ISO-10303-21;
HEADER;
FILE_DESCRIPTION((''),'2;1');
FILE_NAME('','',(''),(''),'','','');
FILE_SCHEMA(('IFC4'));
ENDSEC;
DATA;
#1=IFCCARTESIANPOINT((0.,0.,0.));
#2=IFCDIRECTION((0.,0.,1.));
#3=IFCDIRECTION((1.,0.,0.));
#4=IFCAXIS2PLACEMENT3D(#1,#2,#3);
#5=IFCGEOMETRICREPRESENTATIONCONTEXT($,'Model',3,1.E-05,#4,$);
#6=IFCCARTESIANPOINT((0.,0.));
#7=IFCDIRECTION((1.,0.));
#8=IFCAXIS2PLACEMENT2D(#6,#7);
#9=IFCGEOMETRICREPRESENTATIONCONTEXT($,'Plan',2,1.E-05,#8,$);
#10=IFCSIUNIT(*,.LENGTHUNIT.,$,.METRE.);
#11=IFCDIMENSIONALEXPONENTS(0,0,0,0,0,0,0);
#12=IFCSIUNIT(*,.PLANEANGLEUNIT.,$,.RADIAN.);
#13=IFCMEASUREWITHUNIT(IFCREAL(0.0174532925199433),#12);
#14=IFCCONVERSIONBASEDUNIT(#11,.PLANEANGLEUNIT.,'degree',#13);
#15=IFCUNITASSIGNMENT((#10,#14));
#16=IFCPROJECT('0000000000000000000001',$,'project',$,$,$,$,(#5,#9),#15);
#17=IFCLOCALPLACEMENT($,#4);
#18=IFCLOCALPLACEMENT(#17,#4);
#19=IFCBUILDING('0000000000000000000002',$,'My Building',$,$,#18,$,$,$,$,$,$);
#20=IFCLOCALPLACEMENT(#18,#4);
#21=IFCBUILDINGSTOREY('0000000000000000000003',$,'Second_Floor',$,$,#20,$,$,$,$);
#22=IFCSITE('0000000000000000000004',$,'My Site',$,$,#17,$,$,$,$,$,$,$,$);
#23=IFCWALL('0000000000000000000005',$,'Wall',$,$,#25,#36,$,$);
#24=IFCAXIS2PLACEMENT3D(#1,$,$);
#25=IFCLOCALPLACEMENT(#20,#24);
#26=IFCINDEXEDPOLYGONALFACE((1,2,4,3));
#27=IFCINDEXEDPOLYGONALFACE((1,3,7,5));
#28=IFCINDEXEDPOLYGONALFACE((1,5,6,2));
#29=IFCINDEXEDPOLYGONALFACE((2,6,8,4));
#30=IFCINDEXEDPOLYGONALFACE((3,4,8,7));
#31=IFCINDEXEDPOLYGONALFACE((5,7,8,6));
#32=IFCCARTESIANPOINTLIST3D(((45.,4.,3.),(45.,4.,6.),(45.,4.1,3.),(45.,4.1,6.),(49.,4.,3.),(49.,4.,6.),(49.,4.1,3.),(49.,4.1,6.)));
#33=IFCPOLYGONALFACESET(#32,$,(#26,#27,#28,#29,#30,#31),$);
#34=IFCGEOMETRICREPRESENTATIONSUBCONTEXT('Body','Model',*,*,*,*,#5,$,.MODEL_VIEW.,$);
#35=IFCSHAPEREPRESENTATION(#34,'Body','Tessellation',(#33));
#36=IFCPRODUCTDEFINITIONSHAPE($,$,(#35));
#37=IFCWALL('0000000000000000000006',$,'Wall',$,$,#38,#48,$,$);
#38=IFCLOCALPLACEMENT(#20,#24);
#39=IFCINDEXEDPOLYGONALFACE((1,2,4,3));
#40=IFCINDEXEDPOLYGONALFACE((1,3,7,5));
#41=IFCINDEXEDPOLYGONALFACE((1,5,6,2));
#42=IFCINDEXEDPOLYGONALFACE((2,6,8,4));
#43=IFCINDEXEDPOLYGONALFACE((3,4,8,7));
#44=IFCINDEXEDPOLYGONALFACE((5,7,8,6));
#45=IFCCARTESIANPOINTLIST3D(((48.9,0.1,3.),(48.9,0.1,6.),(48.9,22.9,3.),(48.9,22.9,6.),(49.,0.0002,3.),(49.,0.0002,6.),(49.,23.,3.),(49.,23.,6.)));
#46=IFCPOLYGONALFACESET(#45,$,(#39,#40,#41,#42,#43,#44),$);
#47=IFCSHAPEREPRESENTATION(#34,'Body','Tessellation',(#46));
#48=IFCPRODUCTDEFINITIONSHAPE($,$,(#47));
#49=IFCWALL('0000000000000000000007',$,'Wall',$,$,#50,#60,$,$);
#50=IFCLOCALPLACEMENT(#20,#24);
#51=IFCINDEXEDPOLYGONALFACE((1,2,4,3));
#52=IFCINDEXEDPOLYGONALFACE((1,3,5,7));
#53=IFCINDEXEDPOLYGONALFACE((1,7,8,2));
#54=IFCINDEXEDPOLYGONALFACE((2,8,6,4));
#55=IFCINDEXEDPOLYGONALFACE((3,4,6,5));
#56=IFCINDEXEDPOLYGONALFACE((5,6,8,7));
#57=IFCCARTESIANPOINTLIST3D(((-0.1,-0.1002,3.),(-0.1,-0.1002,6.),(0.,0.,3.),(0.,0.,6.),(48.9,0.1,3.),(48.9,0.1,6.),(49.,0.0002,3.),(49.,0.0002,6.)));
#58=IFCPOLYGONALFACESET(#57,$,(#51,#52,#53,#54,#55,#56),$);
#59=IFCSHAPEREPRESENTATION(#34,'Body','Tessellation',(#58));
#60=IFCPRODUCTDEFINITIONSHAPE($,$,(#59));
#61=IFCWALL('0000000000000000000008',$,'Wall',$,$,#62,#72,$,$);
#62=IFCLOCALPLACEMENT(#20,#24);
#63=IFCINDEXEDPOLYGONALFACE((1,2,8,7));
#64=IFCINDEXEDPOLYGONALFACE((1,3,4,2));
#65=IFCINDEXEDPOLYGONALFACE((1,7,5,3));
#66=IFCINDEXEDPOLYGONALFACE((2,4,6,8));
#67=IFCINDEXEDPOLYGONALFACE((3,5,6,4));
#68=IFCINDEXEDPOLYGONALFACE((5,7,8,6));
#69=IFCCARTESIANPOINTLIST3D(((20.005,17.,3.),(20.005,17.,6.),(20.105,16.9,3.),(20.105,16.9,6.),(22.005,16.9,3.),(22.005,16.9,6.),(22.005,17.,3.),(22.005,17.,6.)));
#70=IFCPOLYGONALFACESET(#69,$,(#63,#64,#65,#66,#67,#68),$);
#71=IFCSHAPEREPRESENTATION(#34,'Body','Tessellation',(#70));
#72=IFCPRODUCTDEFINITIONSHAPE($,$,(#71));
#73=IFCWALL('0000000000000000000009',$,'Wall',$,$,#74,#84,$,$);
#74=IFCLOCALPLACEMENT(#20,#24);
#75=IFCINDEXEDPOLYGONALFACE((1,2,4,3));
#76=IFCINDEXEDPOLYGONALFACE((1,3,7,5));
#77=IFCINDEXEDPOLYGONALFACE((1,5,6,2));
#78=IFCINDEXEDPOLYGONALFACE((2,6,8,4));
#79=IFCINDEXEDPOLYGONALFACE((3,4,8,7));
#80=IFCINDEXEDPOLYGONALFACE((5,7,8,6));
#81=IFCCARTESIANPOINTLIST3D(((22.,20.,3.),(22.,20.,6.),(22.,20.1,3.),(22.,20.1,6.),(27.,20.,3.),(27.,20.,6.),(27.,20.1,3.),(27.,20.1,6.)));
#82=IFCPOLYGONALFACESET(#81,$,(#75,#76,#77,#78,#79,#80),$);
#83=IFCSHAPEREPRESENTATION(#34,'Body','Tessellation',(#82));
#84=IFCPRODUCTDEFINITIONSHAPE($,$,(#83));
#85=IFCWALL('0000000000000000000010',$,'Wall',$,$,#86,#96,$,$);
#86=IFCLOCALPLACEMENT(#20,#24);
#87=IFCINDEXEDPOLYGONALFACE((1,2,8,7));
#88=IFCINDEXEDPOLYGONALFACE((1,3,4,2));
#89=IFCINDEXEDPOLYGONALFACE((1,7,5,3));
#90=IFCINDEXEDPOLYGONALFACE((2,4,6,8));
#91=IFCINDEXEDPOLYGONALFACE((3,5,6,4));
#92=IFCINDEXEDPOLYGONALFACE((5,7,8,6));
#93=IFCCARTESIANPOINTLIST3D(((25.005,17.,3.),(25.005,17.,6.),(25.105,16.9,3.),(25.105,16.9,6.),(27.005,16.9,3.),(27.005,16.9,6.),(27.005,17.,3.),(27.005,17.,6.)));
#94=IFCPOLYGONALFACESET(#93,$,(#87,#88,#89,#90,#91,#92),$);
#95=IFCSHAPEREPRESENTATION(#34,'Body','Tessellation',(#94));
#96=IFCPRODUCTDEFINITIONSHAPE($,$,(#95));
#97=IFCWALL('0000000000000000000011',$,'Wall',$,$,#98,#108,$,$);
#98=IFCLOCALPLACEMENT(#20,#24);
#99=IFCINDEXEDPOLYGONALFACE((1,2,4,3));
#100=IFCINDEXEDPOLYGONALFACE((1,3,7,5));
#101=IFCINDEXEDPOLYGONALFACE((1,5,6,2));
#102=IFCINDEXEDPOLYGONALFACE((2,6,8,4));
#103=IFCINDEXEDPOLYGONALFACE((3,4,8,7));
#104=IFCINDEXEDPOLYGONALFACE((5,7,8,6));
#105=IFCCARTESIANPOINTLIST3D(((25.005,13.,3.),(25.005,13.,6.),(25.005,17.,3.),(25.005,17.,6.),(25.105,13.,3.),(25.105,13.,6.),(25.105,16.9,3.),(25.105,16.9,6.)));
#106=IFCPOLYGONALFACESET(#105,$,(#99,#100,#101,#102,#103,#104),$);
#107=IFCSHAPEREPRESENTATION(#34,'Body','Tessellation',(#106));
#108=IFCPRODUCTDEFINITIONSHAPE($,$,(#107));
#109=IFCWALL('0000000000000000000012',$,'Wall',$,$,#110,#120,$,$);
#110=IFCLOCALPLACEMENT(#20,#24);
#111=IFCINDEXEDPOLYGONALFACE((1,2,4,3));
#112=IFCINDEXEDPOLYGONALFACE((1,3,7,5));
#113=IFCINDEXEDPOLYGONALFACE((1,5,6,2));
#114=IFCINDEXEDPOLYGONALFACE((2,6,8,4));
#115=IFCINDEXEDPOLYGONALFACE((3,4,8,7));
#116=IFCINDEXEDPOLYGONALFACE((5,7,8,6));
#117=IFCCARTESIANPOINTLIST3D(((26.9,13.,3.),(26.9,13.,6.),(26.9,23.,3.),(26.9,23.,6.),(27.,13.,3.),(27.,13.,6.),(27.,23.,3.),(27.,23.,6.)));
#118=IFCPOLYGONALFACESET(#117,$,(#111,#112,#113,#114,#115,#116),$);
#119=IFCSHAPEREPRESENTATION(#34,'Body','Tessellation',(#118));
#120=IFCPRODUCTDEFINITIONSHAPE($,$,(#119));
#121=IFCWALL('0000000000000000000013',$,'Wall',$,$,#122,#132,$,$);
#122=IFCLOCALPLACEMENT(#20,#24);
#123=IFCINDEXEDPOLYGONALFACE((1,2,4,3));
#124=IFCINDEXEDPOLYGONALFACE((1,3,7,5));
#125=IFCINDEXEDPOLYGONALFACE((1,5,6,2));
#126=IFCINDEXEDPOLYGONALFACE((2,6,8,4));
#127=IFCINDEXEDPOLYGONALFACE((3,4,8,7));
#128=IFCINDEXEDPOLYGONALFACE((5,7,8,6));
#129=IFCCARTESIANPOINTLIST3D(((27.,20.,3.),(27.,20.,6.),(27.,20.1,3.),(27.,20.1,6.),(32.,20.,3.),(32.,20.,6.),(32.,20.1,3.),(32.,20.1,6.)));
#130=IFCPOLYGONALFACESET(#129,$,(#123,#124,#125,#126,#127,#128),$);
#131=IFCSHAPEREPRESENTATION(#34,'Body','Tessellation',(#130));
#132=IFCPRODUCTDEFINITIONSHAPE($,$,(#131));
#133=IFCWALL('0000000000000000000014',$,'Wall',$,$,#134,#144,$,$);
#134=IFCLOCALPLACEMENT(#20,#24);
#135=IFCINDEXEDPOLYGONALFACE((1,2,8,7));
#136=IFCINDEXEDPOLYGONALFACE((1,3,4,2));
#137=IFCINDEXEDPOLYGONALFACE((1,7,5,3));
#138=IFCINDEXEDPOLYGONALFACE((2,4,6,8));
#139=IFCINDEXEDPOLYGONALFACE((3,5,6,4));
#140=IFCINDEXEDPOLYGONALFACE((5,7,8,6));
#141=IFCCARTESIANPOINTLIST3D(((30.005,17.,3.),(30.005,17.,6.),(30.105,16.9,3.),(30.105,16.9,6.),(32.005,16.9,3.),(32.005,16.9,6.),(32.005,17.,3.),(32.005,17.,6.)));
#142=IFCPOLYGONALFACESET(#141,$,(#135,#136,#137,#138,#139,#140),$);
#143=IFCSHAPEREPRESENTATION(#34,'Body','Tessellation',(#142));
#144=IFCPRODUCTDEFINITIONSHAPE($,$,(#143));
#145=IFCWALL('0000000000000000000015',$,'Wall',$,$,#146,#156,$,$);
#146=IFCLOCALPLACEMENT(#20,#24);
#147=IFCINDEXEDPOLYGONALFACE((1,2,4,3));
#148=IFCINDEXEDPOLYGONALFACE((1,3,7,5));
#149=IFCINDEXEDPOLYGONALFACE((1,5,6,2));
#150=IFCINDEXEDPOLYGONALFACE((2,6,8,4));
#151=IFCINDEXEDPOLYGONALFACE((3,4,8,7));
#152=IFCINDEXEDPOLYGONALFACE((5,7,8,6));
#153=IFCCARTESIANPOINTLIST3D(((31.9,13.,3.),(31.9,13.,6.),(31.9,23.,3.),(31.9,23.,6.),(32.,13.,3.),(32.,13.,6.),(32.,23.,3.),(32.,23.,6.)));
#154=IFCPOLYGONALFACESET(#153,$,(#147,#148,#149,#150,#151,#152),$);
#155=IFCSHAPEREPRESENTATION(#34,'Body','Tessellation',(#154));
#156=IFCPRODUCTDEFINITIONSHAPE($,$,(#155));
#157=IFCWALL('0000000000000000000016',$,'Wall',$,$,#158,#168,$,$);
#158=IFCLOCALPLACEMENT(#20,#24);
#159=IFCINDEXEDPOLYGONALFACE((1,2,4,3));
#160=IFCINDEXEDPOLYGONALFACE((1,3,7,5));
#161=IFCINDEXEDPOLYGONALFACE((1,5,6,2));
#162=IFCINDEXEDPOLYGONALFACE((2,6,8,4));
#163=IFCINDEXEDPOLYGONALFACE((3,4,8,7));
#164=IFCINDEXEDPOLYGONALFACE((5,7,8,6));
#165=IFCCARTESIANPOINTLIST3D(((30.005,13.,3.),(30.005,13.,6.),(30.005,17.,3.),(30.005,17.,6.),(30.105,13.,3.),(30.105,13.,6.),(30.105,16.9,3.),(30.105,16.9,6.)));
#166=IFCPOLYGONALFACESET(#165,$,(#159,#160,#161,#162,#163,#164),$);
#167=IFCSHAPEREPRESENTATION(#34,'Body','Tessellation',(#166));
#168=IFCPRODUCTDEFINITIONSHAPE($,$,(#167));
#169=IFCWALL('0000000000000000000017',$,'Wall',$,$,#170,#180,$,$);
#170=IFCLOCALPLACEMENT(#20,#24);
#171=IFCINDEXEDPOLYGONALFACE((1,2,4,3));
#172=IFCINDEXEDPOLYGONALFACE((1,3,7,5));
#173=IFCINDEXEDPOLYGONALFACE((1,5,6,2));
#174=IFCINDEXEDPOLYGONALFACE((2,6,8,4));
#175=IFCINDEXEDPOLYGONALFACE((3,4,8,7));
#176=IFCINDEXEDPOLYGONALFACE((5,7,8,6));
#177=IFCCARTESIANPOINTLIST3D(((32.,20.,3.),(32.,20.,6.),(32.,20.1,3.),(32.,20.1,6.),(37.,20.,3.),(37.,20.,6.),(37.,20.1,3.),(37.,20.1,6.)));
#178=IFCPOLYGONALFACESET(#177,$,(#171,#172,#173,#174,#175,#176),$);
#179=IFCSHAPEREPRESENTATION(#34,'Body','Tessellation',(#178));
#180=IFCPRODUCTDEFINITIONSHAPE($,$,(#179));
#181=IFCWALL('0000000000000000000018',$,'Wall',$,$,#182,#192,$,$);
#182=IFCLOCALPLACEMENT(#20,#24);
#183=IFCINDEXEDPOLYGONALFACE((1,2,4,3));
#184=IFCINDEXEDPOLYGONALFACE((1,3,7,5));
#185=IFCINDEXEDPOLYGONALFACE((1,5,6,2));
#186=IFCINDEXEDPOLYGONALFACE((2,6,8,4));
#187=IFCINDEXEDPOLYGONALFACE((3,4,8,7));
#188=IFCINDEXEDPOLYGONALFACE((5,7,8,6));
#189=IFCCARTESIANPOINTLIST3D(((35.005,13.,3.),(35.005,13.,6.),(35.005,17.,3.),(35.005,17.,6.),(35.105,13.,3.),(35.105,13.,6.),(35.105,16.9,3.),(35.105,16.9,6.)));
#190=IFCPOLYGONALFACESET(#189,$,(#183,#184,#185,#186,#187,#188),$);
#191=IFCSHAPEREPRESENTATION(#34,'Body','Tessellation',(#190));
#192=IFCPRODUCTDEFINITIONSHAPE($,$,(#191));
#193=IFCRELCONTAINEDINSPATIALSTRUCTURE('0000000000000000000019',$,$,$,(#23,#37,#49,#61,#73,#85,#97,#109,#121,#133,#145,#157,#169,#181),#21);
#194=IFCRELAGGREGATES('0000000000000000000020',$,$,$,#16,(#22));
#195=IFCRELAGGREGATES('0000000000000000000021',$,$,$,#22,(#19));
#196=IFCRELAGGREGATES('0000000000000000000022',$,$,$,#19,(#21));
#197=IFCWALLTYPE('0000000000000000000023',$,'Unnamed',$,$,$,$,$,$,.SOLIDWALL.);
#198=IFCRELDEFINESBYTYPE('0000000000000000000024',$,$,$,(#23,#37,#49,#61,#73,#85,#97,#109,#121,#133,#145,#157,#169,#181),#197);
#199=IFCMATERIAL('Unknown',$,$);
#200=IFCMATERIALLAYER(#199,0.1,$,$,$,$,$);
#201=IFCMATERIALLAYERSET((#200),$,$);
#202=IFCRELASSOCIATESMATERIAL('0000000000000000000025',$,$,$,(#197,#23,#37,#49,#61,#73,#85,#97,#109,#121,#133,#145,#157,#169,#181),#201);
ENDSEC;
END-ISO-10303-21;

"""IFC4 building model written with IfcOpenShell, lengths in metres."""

from ifc_helpers import new_model, entity, si_unit, converted_unit, frame, origin_with_axes, origin_2d_with_axis, place, context, subcontext, project, spatial, line, indexed_curve, outline, extrude, material, layer, layer_set, layer_usage, type_object, element, save


model = new_model("IFC4")

# Units and contexts
model_context = context("Model", 3, precision=1e-05, world=origin_with_axes())
plan_context = context("Plan", 2, precision=1e-05, world=origin_2d_with_axis())
body_context = subcontext(model_context, "Body", "Model", "MODEL_VIEW")
ifc_project = project(units=[si_unit("LENGTHUNIT", "METRE"), converted_unit("PLANEANGLEUNIT", "degree", entity("IfcReal", 0.0174532925199433), si_unit("PLANEANGLEUNIT", "RADIAN"), dimensions=[0, 0, 0, 0, 0, 0, 0])], contexts=[model_context, plan_context])

# Site, building, storey
site_placement = place(None, origin_with_axes())
site = spatial("IfcSite", under=ifc_project, at=site_placement, Name="My Site")
building_placement = place(site_placement, origin_with_axes())
building = spatial("IfcBuilding", under=site, at=building_placement, Name="My Building")
storey_placement = place(building_placement, origin_with_axes())
storey = spatial("IfcBuildingStorey", under=building, at=storey_placement, Name="Second_Floor")

# Walls
ifc_material = material(Name="Unknown")
ifc_layer = layer(ifc_material, 0.1)
ifc_layer_set = layer_set([ifc_layer])
wall_type = type_object("IfcWallType", Name="Unnamed", PredefinedType="SOLIDWALL", material=ifc_layer_set)
ifc_layer_usage_1 = layer_usage(ifc_layer_set, "AXIS2", "POSITIVE", 0.0)
wall_1_placement = place(storey_placement, frame((45.0, 4.0, 3.0), z_axis=(0.0, 0.0, 1.0), x_axis=(1.0, 0.0, 0.0)))
element("IfcWall", 1, at=wall_1_placement, inside=storey, type_object=wall_type, material=ifc_layer_usage_1, Name="Wall", context=body_context, shape_type="SweptSolid", body=[
    extrude(outline(indexed_curve([(0.0, 0.0), (0.0, 0.1), (4.0, 0.1), (4.0, 0.0)], segments=[line(1, 2, 3, 4, 1)])), origin_with_axes(), (0.0, 0.0, 1.0), 3.0),
])
ifc_layer_usage_2 = layer_usage(ifc_layer_set, "AXIS2", "POSITIVE", 0.0)
wall_2_placement = place(storey_placement, frame((48.9, 22.9, 3.0), z_axis=(0.0, 0.0, 1.0), x_axis=(0.0, -1.0, 0.0)))
element("IfcWall", 2, at=wall_2_placement, inside=storey, type_object=wall_type, material=ifc_layer_usage_2, Name="Wall", context=body_context, shape_type="SweptSolid", body=[
    extrude(outline(indexed_curve([(0.0, 0.0), (-0.1, 0.1), (22.8998, 0.1), (22.8, 0.0)], segments=[line(1, 2, 3, 4, 1)])), origin_with_axes(), (0.0, 0.0, 1.0), 3.0),
])
ifc_layer_usage_3 = layer_usage(ifc_layer_set, "AXIS2", "POSITIVE", 0.0)
wall_3_placement = place(storey_placement, frame((48.9, 0.1, 3.0), z_axis=(0.0, 0.0, 1.0), x_axis=(-0.999998, -0.002045, 0.0)))
element("IfcWall", 3, at=wall_3_placement, inside=storey, type_object=wall_type, material=ifc_layer_usage_3, Name="Wall", context=body_context, shape_type="SweptSolid", body=[
    extrude(outline(indexed_curve([(0.0, 0.0), (-0.0998, 0.1), (49.0003, 0.1), (48.9001, 0.0)], segments=[line(1, 2, 3, 4, 1)])), origin_with_axes(), (0.0, 0.0, 1.0), 3.0),
])
ifc_layer_usage_4 = layer_usage(ifc_layer_set, "AXIS2", "POSITIVE", 0.0)
wall_4_placement = place(storey_placement, frame((22.005, 17.0, 3.0), z_axis=(0.0, 0.0, 1.0), x_axis=(-1.0, 0.0, 0.0)))
element("IfcWall", 4, at=wall_4_placement, inside=storey, type_object=wall_type, material=ifc_layer_usage_4, Name="Wall", context=body_context, shape_type="SweptSolid", body=[
    extrude(outline(indexed_curve([(0.0, 0.0), (0.0, 0.1), (1.9, 0.1), (2.0, 0.0)], segments=[line(1, 2, 3, 4, 1)])), origin_with_axes(), (0.0, 0.0, 1.0), 3.0),
])
ifc_layer_usage_5 = layer_usage(ifc_layer_set, "AXIS2", "POSITIVE", 0.0)
wall_5_placement = place(storey_placement, frame((22.0, 20.0, 3.0), z_axis=(0.0, 0.0, 1.0), x_axis=(1.0, 0.0, 0.0)))
element("IfcWall", 5, at=wall_5_placement, inside=storey, type_object=wall_type, material=ifc_layer_usage_5, Name="Wall", context=body_context, shape_type="SweptSolid", body=[
    extrude(outline(indexed_curve([(0.0, 0.0), (0.0, 0.1), (5.0, 0.1), (5.0, 0.0)], segments=[line(1, 2, 3, 4, 1)])), origin_with_axes(), (0.0, 0.0, 1.0), 3.0),
])
ifc_layer_usage_6 = layer_usage(ifc_layer_set, "AXIS2", "POSITIVE", 0.0)
wall_6_placement = place(storey_placement, frame((27.005, 17.0, 3.0), z_axis=(0.0, 0.0, 1.0), x_axis=(-1.0, 0.0, 0.0)))
element("IfcWall", 6, at=wall_6_placement, inside=storey, type_object=wall_type, material=ifc_layer_usage_6, Name="Wall", context=body_context, shape_type="SweptSolid", body=[
    extrude(outline(indexed_curve([(0.0, 0.0), (0.0, 0.1), (1.9, 0.1), (2.0, 0.0)], segments=[line(1, 2, 3, 4, 1)])), origin_with_axes(), (0.0, 0.0, 1.0), 3.0),
])
ifc_layer_usage_7 = layer_usage(ifc_layer_set, "AXIS2", "POSITIVE", 0.0)
wall_7_placement = place(storey_placement, frame((25.005, 17.0, 3.0), z_axis=(0.0, 0.0, 1.0), x_axis=(0.0, -1.0, 0.0)))
element("IfcWall", 7, at=wall_7_placement, inside=storey, type_object=wall_type, material=ifc_layer_usage_7, Name="Wall", context=body_context, shape_type="SweptSolid", body=[
    extrude(outline(indexed_curve([(0.0, 0.0), (0.1, 0.1), (4.0, 0.1), (4.0, 0.0)], segments=[line(1, 2, 3, 4, 1)])), origin_with_axes(), (0.0, 0.0, 1.0), 3.0),
])
ifc_layer_usage_8 = layer_usage(ifc_layer_set, "AXIS2", "POSITIVE", 0.0)
wall_8_placement = place(storey_placement, frame((26.9, 23.0, 3.0), z_axis=(0.0, 0.0, 1.0), x_axis=(0.0, -1.0, 0.0)))
element("IfcWall", 8, at=wall_8_placement, inside=storey, type_object=wall_type, material=ifc_layer_usage_8, Name="Wall", context=body_context, shape_type="SweptSolid", body=[
    extrude(outline(indexed_curve([(0.0, 0.0), (0.0, 0.1), (10.0, 0.1), (10.0, 0.0)], segments=[line(1, 2, 3, 4, 1)])), origin_with_axes(), (0.0, 0.0, 1.0), 3.0),
])
ifc_layer_usage_9 = layer_usage(ifc_layer_set, "AXIS2", "POSITIVE", 0.0)
wall_9_placement = place(storey_placement, frame((27.0, 20.0, 3.0), z_axis=(0.0, 0.0, 1.0), x_axis=(1.0, 0.0, 0.0)))
element("IfcWall", 9, at=wall_9_placement, inside=storey, type_object=wall_type, material=ifc_layer_usage_9, Name="Wall", context=body_context, shape_type="SweptSolid", body=[
    extrude(outline(indexed_curve([(0.0, 0.0), (0.0, 0.1), (5.0, 0.1), (5.0, 0.0)], segments=[line(1, 2, 3, 4, 1)])), origin_with_axes(), (0.0, 0.0, 1.0), 3.0),
])
ifc_layer_usage_10 = layer_usage(ifc_layer_set, "AXIS2", "POSITIVE", 0.0)
wall_10_placement = place(storey_placement, frame((32.005, 17.0, 3.0), z_axis=(0.0, 0.0, 1.0), x_axis=(-1.0, 0.0, 0.0)))
element("IfcWall", 10, at=wall_10_placement, inside=storey, type_object=wall_type, material=ifc_layer_usage_10, Name="Wall", context=body_context, shape_type="SweptSolid", body=[
    extrude(outline(indexed_curve([(0.0, 0.0), (0.0, 0.1), (1.9, 0.1), (2.0, 0.0)], segments=[line(1, 2, 3, 4, 1)])), origin_with_axes(), (0.0, 0.0, 1.0), 3.0),
])
ifc_layer_usage_11 = layer_usage(ifc_layer_set, "AXIS2", "POSITIVE", 0.0)
wall_11_placement = place(storey_placement, frame((31.9, 23.0, 3.0), z_axis=(0.0, 0.0, 1.0), x_axis=(0.0, -1.0, 0.0)))
element("IfcWall", 11, at=wall_11_placement, inside=storey, type_object=wall_type, material=ifc_layer_usage_11, Name="Wall", context=body_context, shape_type="SweptSolid", body=[
    extrude(outline(indexed_curve([(0.0, 0.0), (0.0, 0.1), (10.0, 0.1), (10.0, 0.0)], segments=[line(1, 2, 3, 4, 1)])), origin_with_axes(), (0.0, 0.0, 1.0), 3.0),
])
ifc_layer_usage_12 = layer_usage(ifc_layer_set, "AXIS2", "POSITIVE", 0.0)
wall_12_placement = place(storey_placement, frame((30.005, 17.0, 3.0), z_axis=(0.0, 0.0, 1.0), x_axis=(0.0, -1.0, 0.0)))
element("IfcWall", 12, at=wall_12_placement, inside=storey, type_object=wall_type, material=ifc_layer_usage_12, Name="Wall", context=body_context, shape_type="SweptSolid", body=[
    extrude(outline(indexed_curve([(0.0, 0.0), (0.1, 0.1), (4.0, 0.1), (4.0, 0.0)], segments=[line(1, 2, 3, 4, 1)])), origin_with_axes(), (0.0, 0.0, 1.0), 3.0),
])
ifc_layer_usage_13 = layer_usage(ifc_layer_set, "AXIS2", "POSITIVE", 0.0)
wall_13_placement = place(storey_placement, frame((32.0, 20.0, 3.0), z_axis=(0.0, 0.0, 1.0), x_axis=(1.0, 0.0, 0.0)))
element("IfcWall", 13, at=wall_13_placement, inside=storey, type_object=wall_type, material=ifc_layer_usage_13, Name="Wall", context=body_context, shape_type="SweptSolid", body=[
    extrude(outline(indexed_curve([(0.0, 0.0), (0.0, 0.1), (5.0, 0.1), (5.0, 0.0)], segments=[line(1, 2, 3, 4, 1)])), origin_with_axes(), (0.0, 0.0, 1.0), 3.0),
])
ifc_layer_usage_14 = layer_usage(ifc_layer_set, "AXIS2", "POSITIVE", 0.0)
wall_14_placement = place(storey_placement, frame((35.005, 17.0, 3.0), z_axis=(0.0, 0.0, 1.0), x_axis=(0.0, -1.0, 0.0)))
element("IfcWall", 14, at=wall_14_placement, inside=storey, type_object=wall_type, material=ifc_layer_usage_14, Name="Wall", context=body_context, shape_type="SweptSolid", body=[
    extrude(outline(indexed_curve([(0.0, 0.0), (0.1, 0.1), (4.0, 0.1), (4.0, 0.0)], segments=[line(1, 2, 3, 4, 1)])), origin_with_axes(), (0.0, 0.0, 1.0), 3.0),
])

save(model, "model.ifc")
